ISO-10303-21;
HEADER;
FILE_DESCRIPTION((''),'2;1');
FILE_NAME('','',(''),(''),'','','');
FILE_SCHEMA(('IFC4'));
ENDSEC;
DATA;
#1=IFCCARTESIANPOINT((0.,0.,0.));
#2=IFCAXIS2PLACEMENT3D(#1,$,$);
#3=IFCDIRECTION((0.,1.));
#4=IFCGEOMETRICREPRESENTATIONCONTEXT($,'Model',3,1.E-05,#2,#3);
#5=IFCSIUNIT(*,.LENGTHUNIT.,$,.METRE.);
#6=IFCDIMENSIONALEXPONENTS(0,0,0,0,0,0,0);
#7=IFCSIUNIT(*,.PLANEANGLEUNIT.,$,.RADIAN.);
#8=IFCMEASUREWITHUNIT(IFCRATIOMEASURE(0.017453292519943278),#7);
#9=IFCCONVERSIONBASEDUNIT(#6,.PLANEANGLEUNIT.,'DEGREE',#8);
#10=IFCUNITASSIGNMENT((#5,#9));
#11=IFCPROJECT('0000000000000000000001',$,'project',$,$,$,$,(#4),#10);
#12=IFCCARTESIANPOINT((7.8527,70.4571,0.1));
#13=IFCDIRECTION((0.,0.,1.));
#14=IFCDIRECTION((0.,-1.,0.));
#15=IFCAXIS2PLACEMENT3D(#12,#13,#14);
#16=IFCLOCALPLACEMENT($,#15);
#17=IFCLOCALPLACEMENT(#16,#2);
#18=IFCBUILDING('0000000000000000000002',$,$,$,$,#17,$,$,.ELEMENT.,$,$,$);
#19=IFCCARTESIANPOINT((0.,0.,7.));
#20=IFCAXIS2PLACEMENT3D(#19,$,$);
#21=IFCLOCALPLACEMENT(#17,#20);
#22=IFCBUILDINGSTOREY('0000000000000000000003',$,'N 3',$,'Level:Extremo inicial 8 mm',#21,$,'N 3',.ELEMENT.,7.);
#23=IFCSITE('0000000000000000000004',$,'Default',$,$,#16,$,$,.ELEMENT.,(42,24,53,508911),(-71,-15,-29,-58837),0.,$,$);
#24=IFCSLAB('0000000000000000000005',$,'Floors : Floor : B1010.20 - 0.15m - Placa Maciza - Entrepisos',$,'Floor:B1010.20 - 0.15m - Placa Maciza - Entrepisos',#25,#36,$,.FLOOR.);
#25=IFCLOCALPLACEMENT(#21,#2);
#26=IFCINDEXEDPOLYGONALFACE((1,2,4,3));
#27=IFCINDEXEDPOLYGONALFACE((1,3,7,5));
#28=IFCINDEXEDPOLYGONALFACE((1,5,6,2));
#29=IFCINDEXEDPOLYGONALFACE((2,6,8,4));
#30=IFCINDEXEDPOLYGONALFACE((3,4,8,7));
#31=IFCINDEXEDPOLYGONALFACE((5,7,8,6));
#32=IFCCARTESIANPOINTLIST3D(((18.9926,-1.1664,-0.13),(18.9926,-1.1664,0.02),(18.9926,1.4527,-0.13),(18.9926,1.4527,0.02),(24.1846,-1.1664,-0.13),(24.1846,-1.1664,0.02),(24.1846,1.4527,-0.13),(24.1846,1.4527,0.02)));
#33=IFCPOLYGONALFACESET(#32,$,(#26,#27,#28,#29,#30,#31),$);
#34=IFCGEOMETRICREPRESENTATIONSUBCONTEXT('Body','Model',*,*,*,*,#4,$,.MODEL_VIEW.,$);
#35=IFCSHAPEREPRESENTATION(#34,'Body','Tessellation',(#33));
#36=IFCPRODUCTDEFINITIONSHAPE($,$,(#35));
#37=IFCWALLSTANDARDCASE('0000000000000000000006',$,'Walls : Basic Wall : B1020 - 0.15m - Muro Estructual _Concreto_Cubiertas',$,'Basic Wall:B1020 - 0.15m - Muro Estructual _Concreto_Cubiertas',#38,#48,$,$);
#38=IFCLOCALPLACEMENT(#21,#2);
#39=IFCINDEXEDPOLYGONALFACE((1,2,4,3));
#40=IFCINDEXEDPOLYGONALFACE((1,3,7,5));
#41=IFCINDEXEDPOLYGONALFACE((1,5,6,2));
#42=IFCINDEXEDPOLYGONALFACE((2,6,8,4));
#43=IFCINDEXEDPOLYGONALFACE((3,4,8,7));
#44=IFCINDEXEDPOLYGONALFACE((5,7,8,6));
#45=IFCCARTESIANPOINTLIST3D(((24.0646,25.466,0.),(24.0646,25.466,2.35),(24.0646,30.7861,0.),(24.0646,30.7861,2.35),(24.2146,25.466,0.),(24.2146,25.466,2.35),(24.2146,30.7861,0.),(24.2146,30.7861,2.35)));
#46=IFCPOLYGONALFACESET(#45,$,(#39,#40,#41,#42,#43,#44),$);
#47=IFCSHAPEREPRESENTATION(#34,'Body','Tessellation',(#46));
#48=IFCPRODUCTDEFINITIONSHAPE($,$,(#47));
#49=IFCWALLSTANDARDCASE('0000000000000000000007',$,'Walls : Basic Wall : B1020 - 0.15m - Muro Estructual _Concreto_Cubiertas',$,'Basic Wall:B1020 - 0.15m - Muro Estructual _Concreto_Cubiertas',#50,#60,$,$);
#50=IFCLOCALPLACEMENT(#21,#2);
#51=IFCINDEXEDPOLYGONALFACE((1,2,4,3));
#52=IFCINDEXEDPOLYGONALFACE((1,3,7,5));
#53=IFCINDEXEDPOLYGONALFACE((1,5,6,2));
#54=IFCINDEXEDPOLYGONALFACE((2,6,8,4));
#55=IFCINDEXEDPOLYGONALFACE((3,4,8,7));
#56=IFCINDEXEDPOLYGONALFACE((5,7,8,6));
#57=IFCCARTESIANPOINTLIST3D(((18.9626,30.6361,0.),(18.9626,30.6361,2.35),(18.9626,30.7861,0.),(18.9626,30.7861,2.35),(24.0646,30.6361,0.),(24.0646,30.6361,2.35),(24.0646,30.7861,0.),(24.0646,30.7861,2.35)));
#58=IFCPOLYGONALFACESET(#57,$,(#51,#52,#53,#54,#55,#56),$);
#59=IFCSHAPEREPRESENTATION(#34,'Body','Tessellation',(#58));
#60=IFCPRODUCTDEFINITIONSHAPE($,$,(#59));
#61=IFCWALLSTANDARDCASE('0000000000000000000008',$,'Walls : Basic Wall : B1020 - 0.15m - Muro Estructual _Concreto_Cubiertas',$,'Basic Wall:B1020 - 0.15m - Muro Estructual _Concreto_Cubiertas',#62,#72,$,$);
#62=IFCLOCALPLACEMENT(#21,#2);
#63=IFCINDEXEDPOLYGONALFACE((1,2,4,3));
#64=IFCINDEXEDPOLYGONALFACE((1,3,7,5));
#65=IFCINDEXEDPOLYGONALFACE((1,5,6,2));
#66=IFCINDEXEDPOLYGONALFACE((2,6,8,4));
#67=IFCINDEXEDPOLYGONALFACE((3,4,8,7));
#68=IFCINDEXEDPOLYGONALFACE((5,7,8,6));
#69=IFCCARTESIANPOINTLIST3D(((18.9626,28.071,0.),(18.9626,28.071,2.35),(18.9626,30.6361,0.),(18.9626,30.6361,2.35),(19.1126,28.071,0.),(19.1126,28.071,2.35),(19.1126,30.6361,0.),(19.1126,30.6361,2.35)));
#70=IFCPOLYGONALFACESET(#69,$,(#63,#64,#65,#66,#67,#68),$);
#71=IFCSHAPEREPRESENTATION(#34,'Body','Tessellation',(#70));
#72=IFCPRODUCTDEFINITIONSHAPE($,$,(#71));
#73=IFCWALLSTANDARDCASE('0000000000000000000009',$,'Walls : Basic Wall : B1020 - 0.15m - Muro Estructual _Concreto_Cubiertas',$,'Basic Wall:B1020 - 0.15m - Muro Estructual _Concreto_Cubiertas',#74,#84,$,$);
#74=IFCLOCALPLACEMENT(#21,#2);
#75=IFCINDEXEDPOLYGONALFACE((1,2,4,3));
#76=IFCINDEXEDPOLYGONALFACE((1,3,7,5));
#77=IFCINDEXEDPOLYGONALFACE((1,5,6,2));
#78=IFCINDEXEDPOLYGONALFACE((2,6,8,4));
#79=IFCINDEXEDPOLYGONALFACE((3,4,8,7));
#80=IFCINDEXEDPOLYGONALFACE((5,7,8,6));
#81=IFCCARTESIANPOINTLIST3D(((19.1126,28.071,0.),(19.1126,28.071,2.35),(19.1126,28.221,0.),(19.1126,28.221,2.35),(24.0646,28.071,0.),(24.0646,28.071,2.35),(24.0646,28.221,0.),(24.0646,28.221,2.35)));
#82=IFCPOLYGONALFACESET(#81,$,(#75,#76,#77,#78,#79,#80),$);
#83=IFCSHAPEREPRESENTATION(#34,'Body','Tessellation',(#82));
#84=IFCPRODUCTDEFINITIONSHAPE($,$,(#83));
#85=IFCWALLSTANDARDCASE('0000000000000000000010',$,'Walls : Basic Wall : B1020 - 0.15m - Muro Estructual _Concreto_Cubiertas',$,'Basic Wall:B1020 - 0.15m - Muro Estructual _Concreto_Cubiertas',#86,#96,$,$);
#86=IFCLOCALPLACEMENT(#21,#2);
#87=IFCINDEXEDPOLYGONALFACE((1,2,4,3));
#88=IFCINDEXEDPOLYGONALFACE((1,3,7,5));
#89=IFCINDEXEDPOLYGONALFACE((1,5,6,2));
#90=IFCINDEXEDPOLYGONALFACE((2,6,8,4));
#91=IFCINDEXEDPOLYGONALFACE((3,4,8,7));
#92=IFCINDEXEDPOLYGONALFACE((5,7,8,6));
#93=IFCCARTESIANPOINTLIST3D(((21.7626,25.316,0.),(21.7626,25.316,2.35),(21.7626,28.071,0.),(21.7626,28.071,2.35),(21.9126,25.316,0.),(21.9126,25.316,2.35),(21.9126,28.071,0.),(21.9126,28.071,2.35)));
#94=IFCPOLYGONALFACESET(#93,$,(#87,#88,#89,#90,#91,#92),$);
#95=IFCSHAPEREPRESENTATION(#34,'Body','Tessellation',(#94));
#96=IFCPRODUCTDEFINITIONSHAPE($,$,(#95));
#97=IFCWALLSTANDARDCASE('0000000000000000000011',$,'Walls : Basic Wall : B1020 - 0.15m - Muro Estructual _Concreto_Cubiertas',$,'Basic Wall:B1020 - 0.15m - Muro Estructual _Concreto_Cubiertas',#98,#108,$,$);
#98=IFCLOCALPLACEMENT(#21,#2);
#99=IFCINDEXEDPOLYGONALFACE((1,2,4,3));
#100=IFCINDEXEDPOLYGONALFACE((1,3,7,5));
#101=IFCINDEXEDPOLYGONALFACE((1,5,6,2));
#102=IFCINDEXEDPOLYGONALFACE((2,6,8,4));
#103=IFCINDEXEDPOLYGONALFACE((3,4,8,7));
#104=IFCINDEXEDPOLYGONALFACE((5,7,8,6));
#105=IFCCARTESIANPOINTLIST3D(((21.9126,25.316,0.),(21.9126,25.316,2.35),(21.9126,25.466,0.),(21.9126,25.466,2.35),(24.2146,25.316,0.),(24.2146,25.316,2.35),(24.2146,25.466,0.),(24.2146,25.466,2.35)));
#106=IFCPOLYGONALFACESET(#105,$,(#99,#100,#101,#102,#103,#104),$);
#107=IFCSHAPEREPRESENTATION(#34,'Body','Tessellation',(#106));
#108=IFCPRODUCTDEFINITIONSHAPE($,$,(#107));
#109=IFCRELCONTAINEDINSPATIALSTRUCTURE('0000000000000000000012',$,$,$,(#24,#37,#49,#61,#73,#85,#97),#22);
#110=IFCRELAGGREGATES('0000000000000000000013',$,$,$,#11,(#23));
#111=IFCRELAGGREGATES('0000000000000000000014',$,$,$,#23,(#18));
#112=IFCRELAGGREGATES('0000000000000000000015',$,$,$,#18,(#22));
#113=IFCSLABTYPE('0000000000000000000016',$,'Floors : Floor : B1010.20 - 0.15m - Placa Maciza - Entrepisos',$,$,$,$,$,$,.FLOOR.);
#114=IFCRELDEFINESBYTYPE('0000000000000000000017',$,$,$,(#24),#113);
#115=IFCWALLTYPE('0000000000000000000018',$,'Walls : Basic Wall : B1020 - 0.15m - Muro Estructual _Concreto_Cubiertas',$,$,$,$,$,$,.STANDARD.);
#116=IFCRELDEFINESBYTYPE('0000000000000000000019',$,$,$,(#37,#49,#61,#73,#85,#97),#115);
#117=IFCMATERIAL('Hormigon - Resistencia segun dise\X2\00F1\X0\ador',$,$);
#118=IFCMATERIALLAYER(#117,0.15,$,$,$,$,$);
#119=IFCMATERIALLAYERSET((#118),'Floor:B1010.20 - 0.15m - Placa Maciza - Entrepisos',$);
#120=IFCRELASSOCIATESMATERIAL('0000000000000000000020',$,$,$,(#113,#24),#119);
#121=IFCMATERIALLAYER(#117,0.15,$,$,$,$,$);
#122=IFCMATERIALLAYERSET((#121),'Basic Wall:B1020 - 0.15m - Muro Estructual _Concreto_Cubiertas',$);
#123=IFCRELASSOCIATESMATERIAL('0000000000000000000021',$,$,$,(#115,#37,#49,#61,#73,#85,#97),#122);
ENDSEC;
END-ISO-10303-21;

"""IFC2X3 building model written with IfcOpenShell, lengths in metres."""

from ifc_helpers import new_model, entity, si_unit, converted_unit, direction, frame, frame_2d, origin, place, context, subcontext, project, spatial, rectangle, extrude, material, layer, layer_set, layer_usage, type_object, element, save


model = new_model("IFC2X3")

# Units and contexts
model_context = context("Model", 3, precision=1e-05, world=origin(), true_north=direction((0.0, 1.0)))
body_context = subcontext(model_context, "Body", "Model", "MODEL_VIEW")
ifc_project = project(units=[si_unit("LENGTHUNIT", "METRE"), converted_unit("PLANEANGLEUNIT", "DEGREE", entity("IfcRatioMeasure", 0.017453292519943278), si_unit("PLANEANGLEUNIT", "RADIAN"), dimensions=[0, 0, 0, 0, 0, 0, 0])], contexts=[model_context])

# Site, building, storey
site_placement = place(None, frame((7.8527, 70.4571, 0.1), z_axis=(0.0, 0.0, 1.0), x_axis=(0.0, -1.0, 0.0)))
site = spatial("IfcSite", under=ifc_project, at=site_placement, Name="Default", CompositionType="ELEMENT", RefLatitude=(42, 24, 53, 508911), RefLongitude=(-71, -15, -29, -58837), RefElevation=0.0)
building_placement = place(site_placement, origin())
building = spatial("IfcBuilding", under=site, at=building_placement, CompositionType="ELEMENT")
storey_placement = place(building_placement, frame((0.0, 0.0, 7.0)))
storey = spatial("IfcBuildingStorey", under=building, at=storey_placement, Name="N 3", ObjectType="Level:Extremo inicial 8 mm", LongName="N 3", CompositionType="ELEMENT", Elevation=7.0)

# Shared definitions
ifc_material_1 = material(Name="Hormigon - Resistencia segun diseñador")
ifc_layer_1 = layer(ifc_material_1, 0.15)
ifc_layer_set_1 = layer_set([ifc_layer_1], Name="Floor:B1010.20 - 0.15m - Placa Maciza - Entrepisos")

# Slab
ifc_layer_usage_1 = layer_usage(ifc_layer_set_1, "AXIS3", "POSITIVE", 0.0)
slab_type_1 = type_object("IfcSlabType", Name="Floors : Floor : B1010.20 - 0.15m - Placa Maciza - Entrepisos", PredefinedType="FLOOR", material=ifc_layer_set_1)
slab_1_placement = place(storey_placement, origin())
element("IfcSlab", 1, at=slab_1_placement, inside=storey, type_object=slab_type_1, material=ifc_layer_usage_1, Name="Floors : Floor : B1010.20 - 0.15m - Placa Maciza - Entrepisos", ObjectType="Floor:B1010.20 - 0.15m - Placa Maciza - Entrepisos", PredefinedType="FLOOR", context=body_context, shape_type="SweptSolid", body=[
    extrude(rectangle(XDim=2.6191, YDim=5.1921, at=frame_2d((0.0, 0.0), x_axis=(1.0, 0.0))), frame((21.5886, 0.1431, 0.02), z_axis=(0.0, 0.0, -1.0), x_axis=(0.0, 1.0, 0.0)), (0.0, 0.0, 1.0), 0.15),
])

# Walls
ifc_layer_2 = layer(ifc_material_1, 0.15)
ifc_layer_set_2 = layer_set([ifc_layer_2], Name="Basic Wall:B1020 - 0.15m - Muro Estructual _Concreto_Cubiertas")
ifc_layer_usage_2 = layer_usage(ifc_layer_set_2, "AXIS2", "NEGATIVE", 0.075)
wall_type = type_object("IfcWallType", Name="Walls : Basic Wall : B1020 - 0.15m - Muro Estructual _Concreto_Cubiertas", PredefinedType="STANDARD", material=ifc_layer_set_2)
wall_1_placement = place(storey_placement, frame((24.1396, 30.7861, 0.0), z_axis=(0.0, 0.0, 1.0), x_axis=(0.0, -1.0, 0.0)))
element("IfcWallStandardCase", 2, at=wall_1_placement, inside=storey, type_object=wall_type, material=ifc_layer_usage_2, Name="Walls : Basic Wall : B1020 - 0.15m - Muro Estructual _Concreto_Cubiertas", ObjectType="Basic Wall:B1020 - 0.15m - Muro Estructual _Concreto_Cubiertas", context=body_context, shape_type="SweptSolid", body=[
    extrude(rectangle(XDim=5.3201, YDim=0.15, at=frame_2d((2.66, 0.0), x_axis=(-1.0, 0.0))), origin(), (0.0, 0.0, 1.0), 2.35),
])
ifc_layer_usage_3 = layer_usage(ifc_layer_set_2, "AXIS2", "NEGATIVE", 0.075)
wall_2_placement = place(storey_placement, frame((24.0646, 30.7111, 0.0), z_axis=(0.0, 0.0, 1.0), x_axis=(-1.0, 0.0, 0.0)))
element("IfcWallStandardCase", 3, at=wall_2_placement, inside=storey, type_object=wall_type, material=ifc_layer_usage_3, Name="Walls : Basic Wall : B1020 - 0.15m - Muro Estructual _Concreto_Cubiertas", ObjectType="Basic Wall:B1020 - 0.15m - Muro Estructual _Concreto_Cubiertas", context=body_context, shape_type="SweptSolid", body=[
    extrude(rectangle(XDim=5.1021, YDim=0.15, at=frame_2d((2.551, 0.0), x_axis=(-1.0, 0.0))), origin(), (0.0, 0.0, 1.0), 2.35),
])
ifc_layer_usage_4 = layer_usage(ifc_layer_set_2, "AXIS2", "NEGATIVE", 0.075)
wall_3_placement = place(storey_placement, frame((19.0376, 30.6361, 0.0), z_axis=(0.0, 0.0, 1.0), x_axis=(0.0, -1.0, 0.0)))
element("IfcWallStandardCase", 4, at=wall_3_placement, inside=storey, type_object=wall_type, material=ifc_layer_usage_4, Name="Walls : Basic Wall : B1020 - 0.15m - Muro Estructual _Concreto_Cubiertas", ObjectType="Basic Wall:B1020 - 0.15m - Muro Estructual _Concreto_Cubiertas", context=body_context, shape_type="SweptSolid", body=[
    extrude(rectangle(XDim=2.5651, YDim=0.15, at=frame_2d((1.2825, 0.0), x_axis=(-1.0, 0.0))), origin(), (0.0, 0.0, 1.0), 2.35),
])
ifc_layer_usage_5 = layer_usage(ifc_layer_set_2, "AXIS2", "NEGATIVE", 0.075)
wall_4_placement = place(storey_placement, frame((19.1126, 28.146, 0.0)))
element("IfcWallStandardCase", 5, at=wall_4_placement, inside=storey, type_object=wall_type, material=ifc_layer_usage_5, Name="Walls : Basic Wall : B1020 - 0.15m - Muro Estructual _Concreto_Cubiertas", ObjectType="Basic Wall:B1020 - 0.15m - Muro Estructual _Concreto_Cubiertas", context=body_context, shape_type="SweptSolid", body=[
    extrude(rectangle(XDim=4.9521, YDim=0.15, at=frame_2d((2.476, 0.0), x_axis=(-1.0, 0.0))), origin(), (0.0, 0.0, 1.0), 2.35),
])
ifc_layer_usage_6 = layer_usage(ifc_layer_set_2, "AXIS2", "NEGATIVE", 0.075)
wall_5_placement = place(storey_placement, frame((21.8376, 28.071, 0.0), z_axis=(0.0, 0.0, 1.0), x_axis=(0.0, -1.0, 0.0)))
element("IfcWallStandardCase", 6, at=wall_5_placement, inside=storey, type_object=wall_type, material=ifc_layer_usage_6, Name="Walls : Basic Wall : B1020 - 0.15m - Muro Estructual _Concreto_Cubiertas", ObjectType="Basic Wall:B1020 - 0.15m - Muro Estructual _Concreto_Cubiertas", context=body_context, shape_type="SweptSolid", body=[
    extrude(rectangle(XDim=2.755, YDim=0.15, at=frame_2d((1.3775, 0.0), x_axis=(-1.0, 0.0))), origin(), (0.0, 0.0, 1.0), 2.35),
])
ifc_layer_usage_7 = layer_usage(ifc_layer_set_2, "AXIS2", "NEGATIVE", 0.075)
wall_6_placement = place(storey_placement, frame((21.9126, 25.391, 0.0)))
element("IfcWallStandardCase", 7, at=wall_6_placement, inside=storey, type_object=wall_type, material=ifc_layer_usage_7, Name="Walls : Basic Wall : B1020 - 0.15m - Muro Estructual _Concreto_Cubiertas", ObjectType="Basic Wall:B1020 - 0.15m - Muro Estructual _Concreto_Cubiertas", context=body_context, shape_type="SweptSolid", body=[
    extrude(rectangle(XDim=2.3021, YDim=0.15, at=frame_2d((1.151, 0.0), x_axis=(-1.0, 0.0))), origin(), (0.0, 0.0, 1.0), 2.35),
])

save(model, "model.ifc")
